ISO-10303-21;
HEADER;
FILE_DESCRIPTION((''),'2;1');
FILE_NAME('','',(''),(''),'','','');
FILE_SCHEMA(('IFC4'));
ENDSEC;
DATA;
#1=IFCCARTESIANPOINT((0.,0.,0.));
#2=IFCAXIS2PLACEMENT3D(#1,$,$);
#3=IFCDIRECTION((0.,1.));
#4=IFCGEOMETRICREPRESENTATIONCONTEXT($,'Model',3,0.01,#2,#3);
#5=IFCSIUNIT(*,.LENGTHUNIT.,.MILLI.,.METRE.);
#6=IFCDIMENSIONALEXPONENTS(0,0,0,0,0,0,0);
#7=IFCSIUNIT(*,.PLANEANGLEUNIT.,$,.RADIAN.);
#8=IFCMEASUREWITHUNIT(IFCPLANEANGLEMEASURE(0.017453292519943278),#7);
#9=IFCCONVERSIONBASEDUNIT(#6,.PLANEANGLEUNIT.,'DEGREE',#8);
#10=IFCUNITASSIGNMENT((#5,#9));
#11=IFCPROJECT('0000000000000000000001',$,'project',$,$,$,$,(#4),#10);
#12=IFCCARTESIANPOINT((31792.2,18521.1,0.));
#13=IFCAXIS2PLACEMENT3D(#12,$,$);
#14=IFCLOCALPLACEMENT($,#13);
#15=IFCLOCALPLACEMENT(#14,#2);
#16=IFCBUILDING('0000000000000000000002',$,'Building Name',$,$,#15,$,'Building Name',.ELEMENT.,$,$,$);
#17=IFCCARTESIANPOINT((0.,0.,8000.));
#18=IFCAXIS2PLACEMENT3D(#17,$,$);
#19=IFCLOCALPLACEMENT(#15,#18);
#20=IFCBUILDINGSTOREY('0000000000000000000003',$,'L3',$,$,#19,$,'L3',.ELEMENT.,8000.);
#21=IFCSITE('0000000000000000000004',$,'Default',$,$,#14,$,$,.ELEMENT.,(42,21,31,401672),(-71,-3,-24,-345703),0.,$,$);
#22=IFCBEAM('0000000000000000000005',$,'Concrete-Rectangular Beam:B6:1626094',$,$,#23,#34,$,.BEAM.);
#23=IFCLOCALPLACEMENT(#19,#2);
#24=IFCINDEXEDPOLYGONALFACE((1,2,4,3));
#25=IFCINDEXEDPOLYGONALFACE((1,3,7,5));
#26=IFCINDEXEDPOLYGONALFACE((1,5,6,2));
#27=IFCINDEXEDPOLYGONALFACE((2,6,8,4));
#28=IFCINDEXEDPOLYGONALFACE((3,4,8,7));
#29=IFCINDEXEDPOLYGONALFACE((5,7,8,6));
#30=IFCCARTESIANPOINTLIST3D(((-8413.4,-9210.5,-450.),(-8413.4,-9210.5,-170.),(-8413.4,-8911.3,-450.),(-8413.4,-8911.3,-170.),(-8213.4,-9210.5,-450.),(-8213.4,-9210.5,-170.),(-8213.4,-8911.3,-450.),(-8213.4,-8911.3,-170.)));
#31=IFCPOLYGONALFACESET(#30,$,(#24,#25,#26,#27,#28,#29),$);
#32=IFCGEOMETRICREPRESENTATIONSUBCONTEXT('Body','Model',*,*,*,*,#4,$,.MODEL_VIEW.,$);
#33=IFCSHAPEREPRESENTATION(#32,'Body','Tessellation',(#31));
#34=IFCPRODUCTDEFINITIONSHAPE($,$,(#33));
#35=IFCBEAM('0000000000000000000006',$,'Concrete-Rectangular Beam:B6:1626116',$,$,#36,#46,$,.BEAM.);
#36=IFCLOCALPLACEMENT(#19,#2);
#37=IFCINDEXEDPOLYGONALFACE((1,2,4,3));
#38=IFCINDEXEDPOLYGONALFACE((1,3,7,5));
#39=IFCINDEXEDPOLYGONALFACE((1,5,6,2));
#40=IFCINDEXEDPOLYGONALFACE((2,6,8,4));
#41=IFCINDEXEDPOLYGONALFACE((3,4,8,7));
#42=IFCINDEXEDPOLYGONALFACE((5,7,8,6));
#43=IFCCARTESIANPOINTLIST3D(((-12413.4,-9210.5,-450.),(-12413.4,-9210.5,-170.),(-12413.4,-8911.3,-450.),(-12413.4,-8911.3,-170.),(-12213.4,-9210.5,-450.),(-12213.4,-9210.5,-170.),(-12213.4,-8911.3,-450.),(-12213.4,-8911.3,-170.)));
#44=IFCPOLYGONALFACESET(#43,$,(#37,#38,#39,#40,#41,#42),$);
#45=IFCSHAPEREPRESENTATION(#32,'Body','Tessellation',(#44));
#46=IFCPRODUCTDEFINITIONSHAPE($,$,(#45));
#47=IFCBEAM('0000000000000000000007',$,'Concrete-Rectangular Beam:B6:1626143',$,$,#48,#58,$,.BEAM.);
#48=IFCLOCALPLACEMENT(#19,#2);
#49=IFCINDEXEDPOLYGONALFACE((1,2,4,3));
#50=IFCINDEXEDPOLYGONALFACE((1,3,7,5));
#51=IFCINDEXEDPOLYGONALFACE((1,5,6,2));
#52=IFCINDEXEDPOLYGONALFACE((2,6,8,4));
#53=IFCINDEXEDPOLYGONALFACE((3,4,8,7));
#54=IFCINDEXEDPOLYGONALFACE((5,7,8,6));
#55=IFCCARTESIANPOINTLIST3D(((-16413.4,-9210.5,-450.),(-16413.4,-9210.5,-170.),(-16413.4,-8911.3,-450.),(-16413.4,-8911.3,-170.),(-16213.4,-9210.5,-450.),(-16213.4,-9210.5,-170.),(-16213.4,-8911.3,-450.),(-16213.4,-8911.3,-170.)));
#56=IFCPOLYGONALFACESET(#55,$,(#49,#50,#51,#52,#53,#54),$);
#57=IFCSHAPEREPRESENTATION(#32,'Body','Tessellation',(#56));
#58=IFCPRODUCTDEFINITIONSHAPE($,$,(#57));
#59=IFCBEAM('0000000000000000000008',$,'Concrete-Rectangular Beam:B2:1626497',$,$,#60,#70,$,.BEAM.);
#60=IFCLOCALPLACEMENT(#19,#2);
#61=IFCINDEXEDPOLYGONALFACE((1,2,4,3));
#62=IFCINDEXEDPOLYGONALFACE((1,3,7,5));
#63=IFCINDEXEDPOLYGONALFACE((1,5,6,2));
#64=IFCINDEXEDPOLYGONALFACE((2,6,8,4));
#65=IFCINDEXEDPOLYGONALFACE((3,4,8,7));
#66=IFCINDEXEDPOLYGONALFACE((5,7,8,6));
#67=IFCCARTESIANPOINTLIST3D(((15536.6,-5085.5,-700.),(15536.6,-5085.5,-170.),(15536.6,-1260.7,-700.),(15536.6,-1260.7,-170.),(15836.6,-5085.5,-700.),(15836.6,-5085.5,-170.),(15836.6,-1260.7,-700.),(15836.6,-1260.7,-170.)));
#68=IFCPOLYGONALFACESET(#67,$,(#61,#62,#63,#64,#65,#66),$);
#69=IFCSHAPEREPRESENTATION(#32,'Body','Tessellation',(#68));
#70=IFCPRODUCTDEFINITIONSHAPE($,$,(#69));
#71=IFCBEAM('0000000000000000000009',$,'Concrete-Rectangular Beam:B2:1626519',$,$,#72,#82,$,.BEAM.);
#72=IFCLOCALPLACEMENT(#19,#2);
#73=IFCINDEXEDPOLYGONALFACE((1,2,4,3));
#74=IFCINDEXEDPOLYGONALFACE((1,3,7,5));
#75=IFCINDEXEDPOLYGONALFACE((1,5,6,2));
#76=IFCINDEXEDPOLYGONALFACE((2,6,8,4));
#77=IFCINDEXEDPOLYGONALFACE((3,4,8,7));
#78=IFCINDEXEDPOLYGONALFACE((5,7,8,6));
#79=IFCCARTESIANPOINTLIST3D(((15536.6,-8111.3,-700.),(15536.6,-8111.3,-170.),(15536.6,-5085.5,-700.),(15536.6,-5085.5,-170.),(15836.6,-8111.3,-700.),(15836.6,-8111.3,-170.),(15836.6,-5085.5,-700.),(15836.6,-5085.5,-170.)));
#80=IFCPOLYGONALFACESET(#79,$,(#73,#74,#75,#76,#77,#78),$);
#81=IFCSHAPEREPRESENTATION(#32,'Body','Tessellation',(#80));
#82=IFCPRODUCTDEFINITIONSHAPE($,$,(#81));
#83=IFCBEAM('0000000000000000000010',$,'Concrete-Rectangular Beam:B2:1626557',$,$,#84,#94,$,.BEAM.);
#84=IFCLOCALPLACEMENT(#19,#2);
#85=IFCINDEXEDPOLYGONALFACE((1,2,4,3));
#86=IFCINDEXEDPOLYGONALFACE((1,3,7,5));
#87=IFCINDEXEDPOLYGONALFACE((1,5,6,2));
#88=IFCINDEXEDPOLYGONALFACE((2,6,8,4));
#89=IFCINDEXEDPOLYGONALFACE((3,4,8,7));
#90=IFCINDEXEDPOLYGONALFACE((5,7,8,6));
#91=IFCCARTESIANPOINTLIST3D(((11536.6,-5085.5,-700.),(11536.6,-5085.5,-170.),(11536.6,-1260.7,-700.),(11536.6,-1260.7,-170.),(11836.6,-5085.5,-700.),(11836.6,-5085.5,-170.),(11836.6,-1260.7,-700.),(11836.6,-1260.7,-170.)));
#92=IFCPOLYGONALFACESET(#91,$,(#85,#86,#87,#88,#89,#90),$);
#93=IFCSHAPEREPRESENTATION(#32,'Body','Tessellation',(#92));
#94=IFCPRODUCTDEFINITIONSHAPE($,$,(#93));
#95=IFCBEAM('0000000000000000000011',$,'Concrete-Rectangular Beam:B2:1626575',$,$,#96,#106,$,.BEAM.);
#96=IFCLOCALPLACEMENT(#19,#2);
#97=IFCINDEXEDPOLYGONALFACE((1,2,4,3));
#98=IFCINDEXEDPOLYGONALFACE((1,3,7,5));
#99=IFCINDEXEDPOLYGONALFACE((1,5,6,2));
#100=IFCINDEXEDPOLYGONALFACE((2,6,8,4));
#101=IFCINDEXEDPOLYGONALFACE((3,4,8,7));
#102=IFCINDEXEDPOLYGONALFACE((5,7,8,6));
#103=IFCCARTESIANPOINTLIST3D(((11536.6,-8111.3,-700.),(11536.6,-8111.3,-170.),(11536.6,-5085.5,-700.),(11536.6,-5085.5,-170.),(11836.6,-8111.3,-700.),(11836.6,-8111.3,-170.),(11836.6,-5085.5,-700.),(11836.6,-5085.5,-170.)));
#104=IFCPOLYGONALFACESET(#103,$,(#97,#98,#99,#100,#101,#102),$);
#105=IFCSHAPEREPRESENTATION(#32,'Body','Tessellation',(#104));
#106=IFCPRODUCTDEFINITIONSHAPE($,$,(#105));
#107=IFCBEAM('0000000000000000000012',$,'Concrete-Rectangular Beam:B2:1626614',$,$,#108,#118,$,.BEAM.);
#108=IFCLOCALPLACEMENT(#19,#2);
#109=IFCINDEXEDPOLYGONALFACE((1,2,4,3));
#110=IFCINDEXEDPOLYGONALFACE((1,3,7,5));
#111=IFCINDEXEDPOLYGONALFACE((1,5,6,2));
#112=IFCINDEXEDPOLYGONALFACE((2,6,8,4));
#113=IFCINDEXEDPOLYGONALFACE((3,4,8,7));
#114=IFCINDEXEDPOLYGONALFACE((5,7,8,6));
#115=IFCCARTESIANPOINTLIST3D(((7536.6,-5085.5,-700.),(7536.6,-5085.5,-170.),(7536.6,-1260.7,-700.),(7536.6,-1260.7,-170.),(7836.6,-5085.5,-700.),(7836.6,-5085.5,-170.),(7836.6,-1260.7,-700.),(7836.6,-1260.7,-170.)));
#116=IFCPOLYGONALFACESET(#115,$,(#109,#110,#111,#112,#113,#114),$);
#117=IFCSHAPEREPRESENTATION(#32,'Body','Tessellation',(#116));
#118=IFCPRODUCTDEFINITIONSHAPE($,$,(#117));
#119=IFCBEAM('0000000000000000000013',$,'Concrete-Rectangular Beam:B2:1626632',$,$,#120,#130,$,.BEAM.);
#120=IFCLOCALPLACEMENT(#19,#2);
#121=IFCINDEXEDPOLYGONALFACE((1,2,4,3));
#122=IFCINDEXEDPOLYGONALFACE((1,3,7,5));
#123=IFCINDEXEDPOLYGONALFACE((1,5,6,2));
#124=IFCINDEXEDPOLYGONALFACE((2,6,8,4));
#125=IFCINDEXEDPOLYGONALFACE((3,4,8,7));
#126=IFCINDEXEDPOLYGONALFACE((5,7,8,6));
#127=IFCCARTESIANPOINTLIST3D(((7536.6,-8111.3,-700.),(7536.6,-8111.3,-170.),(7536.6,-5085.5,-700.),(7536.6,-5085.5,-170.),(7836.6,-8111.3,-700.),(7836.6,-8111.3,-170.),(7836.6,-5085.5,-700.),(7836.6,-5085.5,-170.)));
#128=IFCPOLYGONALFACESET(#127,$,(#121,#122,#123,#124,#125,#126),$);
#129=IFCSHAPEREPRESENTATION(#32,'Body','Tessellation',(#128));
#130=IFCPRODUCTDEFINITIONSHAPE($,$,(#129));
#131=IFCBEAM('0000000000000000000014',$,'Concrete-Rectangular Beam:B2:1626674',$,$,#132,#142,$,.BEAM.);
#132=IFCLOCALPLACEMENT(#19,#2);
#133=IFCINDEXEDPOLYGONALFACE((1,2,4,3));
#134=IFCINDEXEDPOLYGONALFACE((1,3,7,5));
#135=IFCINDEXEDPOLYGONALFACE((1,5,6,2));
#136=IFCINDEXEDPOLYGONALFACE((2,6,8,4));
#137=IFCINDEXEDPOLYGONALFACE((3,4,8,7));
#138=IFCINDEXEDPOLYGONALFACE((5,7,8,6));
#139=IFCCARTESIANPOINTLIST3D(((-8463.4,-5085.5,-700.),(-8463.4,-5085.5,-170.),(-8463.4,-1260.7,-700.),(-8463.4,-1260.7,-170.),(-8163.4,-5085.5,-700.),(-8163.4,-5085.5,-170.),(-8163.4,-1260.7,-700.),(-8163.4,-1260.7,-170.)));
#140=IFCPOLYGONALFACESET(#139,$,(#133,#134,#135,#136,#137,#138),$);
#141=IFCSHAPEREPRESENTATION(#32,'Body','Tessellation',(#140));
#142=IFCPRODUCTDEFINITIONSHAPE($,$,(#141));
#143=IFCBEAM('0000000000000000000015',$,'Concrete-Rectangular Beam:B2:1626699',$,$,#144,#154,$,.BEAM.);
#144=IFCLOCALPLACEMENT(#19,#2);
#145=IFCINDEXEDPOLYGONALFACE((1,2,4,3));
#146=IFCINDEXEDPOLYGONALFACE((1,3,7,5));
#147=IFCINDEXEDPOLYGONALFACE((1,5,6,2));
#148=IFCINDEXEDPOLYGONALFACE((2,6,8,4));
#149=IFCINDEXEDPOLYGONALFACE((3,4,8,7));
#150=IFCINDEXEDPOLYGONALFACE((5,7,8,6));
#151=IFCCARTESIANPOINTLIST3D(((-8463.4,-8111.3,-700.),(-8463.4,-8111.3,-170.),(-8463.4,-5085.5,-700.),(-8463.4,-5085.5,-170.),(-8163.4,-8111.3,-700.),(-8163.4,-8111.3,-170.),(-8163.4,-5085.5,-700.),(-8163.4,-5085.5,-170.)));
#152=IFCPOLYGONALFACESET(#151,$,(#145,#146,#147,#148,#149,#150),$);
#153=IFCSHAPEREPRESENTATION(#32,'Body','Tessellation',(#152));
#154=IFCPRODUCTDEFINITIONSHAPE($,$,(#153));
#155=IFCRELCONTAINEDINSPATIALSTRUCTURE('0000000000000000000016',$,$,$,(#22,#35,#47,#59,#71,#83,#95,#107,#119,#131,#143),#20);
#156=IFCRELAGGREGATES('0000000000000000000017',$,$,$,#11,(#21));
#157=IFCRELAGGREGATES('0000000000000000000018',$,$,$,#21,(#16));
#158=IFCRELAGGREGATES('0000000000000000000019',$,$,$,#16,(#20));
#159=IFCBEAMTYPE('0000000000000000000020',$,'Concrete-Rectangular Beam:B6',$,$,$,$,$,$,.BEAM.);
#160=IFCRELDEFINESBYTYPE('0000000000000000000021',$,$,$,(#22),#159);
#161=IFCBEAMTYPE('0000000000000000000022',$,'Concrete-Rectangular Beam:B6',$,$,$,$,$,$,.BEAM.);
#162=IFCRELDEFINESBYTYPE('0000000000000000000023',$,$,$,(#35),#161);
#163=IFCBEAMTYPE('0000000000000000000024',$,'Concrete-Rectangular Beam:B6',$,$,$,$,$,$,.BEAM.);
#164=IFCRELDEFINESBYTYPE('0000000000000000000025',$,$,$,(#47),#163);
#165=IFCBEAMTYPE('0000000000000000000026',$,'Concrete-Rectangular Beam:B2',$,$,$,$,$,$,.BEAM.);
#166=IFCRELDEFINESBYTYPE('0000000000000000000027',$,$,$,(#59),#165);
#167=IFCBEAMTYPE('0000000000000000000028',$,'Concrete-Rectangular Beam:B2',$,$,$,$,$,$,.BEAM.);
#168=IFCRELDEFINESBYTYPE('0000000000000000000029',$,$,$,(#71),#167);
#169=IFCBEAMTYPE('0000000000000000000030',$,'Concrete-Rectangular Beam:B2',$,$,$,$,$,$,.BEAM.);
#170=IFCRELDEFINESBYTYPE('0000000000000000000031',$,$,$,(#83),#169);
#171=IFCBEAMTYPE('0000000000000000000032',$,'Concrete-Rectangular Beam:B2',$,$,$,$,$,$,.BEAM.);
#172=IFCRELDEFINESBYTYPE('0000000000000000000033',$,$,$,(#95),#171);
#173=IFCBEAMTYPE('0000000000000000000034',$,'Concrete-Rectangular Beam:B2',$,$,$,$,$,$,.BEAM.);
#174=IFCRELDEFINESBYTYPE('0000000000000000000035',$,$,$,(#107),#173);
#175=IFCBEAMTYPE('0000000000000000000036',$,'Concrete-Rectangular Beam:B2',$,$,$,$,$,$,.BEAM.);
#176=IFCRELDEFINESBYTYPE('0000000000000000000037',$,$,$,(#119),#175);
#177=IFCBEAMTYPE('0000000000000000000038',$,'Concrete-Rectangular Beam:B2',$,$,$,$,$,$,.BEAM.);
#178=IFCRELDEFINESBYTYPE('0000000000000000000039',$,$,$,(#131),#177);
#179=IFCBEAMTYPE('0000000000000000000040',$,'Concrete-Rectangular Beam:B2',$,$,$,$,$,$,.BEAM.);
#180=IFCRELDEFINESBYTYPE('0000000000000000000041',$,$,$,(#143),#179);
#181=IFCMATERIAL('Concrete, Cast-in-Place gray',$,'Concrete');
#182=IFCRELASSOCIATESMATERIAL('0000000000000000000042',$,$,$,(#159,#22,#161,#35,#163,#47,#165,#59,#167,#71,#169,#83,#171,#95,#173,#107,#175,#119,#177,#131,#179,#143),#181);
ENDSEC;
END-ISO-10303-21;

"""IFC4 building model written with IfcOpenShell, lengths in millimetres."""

from ifc_helpers import new_model, entity, si_unit, converted_unit, direction, frame, origin, place, context, subcontext, project, spatial, indexed_curve, outline, extrude, source, transform, mapped, material, type_object, type_shapes, element, save


model = new_model("IFC4")

# Units and contexts
model_context = context("Model", 3, precision=0.01, world=origin(), true_north=direction((0.0, 1.0)))
body_context = subcontext(model_context, "Body", "Model", "MODEL_VIEW")
ifc_project = project(units=[si_unit("LENGTHUNIT", "METRE", prefix="MILLI"), converted_unit("PLANEANGLEUNIT", "DEGREE", entity("IfcPlaneAngleMeasure", 0.017453292519943278), si_unit("PLANEANGLEUNIT", "RADIAN"), dimensions=[0, 0, 0, 0, 0, 0, 0])], contexts=[model_context])

# Site, building, storey
site_placement = place(None, frame((31792.2, 18521.1, 0.0)))
site = spatial("IfcSite", under=ifc_project, at=site_placement, Name="Default", CompositionType="ELEMENT", RefLatitude=(42, 21, 31, 401672), RefLongitude=(-71, -3, -24, -345703), RefElevation=0.0)
building_placement = place(site_placement, origin())
building = spatial("IfcBuilding", under=site, at=building_placement, Name="Building Name", LongName="Building Name", CompositionType="ELEMENT")
storey_placement = place(building_placement, frame((0.0, 0.0, 8000.0)))
storey = spatial("IfcBuildingStorey", under=building, at=storey_placement, Name="L3", LongName="L3", CompositionType="ELEMENT", Elevation=8000.0)

# Beams
ifc_material = material(Name="Concrete, Cast-in-Place gray", Category="Concrete")
beam_type_1 = type_object("IfcBeamType", Name="Concrete-Rectangular Beam:B6", PredefinedType="BEAM", material=ifc_material)
shared_shape_1 = source(origin(), body_context, "Body", "SweptSolid", [
    extrude(outline(indexed_curve([(-100.0, -140.0), (100.0, -140.0), (100.0, 140.0), (-100.0, 140.0), (-100.0, -140.0)], self_intersect=False)), frame((-8313.4, -8911.3, 7690.0), z_axis=(0.0, -1.0, 0.0), x_axis=(-1.0, 0.0, 0.0)), (0.0, 0.0, 1.0), 299.2),
])
type_shapes(beam_type_1, [shared_shape_1])
beam_1_placement = place(storey_placement, frame((0.0, 0.0, -8000.0)))
element("IfcBeam", 1, at=beam_1_placement, inside=storey, type_object=beam_type_1, material=ifc_material, Name="Concrete-Rectangular Beam:B6:1626094", PredefinedType="BEAM", context=body_context, shape_type="MappedRepresentation", body=[
    mapped(shared_shape_1, transform((0.0, 0.0, 0.0), scale=1.0)),
])
beam_type_2 = type_object("IfcBeamType", Name="Concrete-Rectangular Beam:B6", PredefinedType="BEAM", material=ifc_material)
shared_shape_2 = source(origin(), body_context, "Body", "SweptSolid", [
    extrude(outline(indexed_curve([(-100.0, -140.0), (100.0, -140.0), (100.0, 140.0), (-100.0, 140.0), (-100.0, -140.0)], self_intersect=False)), frame((-12313.4, -8911.3, 7690.0), z_axis=(0.0, -1.0, 0.0), x_axis=(-1.0, 0.0, 0.0)), (0.0, 0.0, 1.0), 299.2),
])
type_shapes(beam_type_2, [shared_shape_2])
beam_2_placement = place(storey_placement, frame((0.0, 0.0, -8000.0)))
element("IfcBeam", 2, at=beam_2_placement, inside=storey, type_object=beam_type_2, material=ifc_material, Name="Concrete-Rectangular Beam:B6:1626116", PredefinedType="BEAM", context=body_context, shape_type="MappedRepresentation", body=[
    mapped(shared_shape_2, transform((0.0, 0.0, 0.0), scale=1.0)),
])
beam_type_3 = type_object("IfcBeamType", Name="Concrete-Rectangular Beam:B6", PredefinedType="BEAM", material=ifc_material)
shared_shape_3 = source(origin(), body_context, "Body", "SweptSolid", [
    extrude(outline(indexed_curve([(-100.0, -140.0), (100.0, -140.0), (100.0, 140.0), (-100.0, 140.0), (-100.0, -140.0)], self_intersect=False)), frame((-16313.4, -8911.3, 7690.0), z_axis=(0.0, -1.0, 0.0), x_axis=(-1.0, 0.0, 0.0)), (0.0, 0.0, 1.0), 299.2),
])
type_shapes(beam_type_3, [shared_shape_3])
beam_3_placement = place(storey_placement, frame((0.0, 0.0, -8000.0)))
element("IfcBeam", 3, at=beam_3_placement, inside=storey, type_object=beam_type_3, material=ifc_material, Name="Concrete-Rectangular Beam:B6:1626143", PredefinedType="BEAM", context=body_context, shape_type="MappedRepresentation", body=[
    mapped(shared_shape_3, transform((0.0, 0.0, 0.0), scale=1.0)),
])
beam_type_4 = type_object("IfcBeamType", Name="Concrete-Rectangular Beam:B2", PredefinedType="BEAM", material=ifc_material)
shared_shape_4 = source(origin(), body_context, "Body", "SweptSolid", [
    extrude(outline(indexed_curve([(-150.0, -265.0), (150.0, -265.0), (150.0, 265.0), (-150.0, 265.0), (-150.0, -265.0)], self_intersect=False)), frame((15686.6, -1260.7, 7565.0), z_axis=(0.0, -1.0, 0.0), x_axis=(-1.0, 0.0, 0.0)), (0.0, 0.0, 1.0), 3824.8),
])
type_shapes(beam_type_4, [shared_shape_4])
beam_4_placement = place(storey_placement, frame((0.0, 0.0, -8000.0)))
element("IfcBeam", 4, at=beam_4_placement, inside=storey, type_object=beam_type_4, material=ifc_material, Name="Concrete-Rectangular Beam:B2:1626497", PredefinedType="BEAM", context=body_context, shape_type="MappedRepresentation", body=[
    mapped(shared_shape_4, transform((0.0, 0.0, 0.0), scale=1.0)),
])
beam_type_5 = type_object("IfcBeamType", Name="Concrete-Rectangular Beam:B2", PredefinedType="BEAM", material=ifc_material)
shared_shape_5 = source(origin(), body_context, "Body", "SweptSolid", [
    extrude(outline(indexed_curve([(-150.0, -265.0), (150.0, -265.0), (150.0, 265.0), (-150.0, 265.0), (-150.0, -265.0)], self_intersect=False)), frame((15686.6, -5085.5, 7565.0), z_axis=(0.0, -1.0, 0.0), x_axis=(-1.0, 0.0, 0.0)), (0.0, 0.0, 1.0), 3025.8),
])
type_shapes(beam_type_5, [shared_shape_5])
beam_5_placement = place(storey_placement, frame((0.0, 0.0, -8000.0)))
element("IfcBeam", 5, at=beam_5_placement, inside=storey, type_object=beam_type_5, material=ifc_material, Name="Concrete-Rectangular Beam:B2:1626519", PredefinedType="BEAM", context=body_context, shape_type="MappedRepresentation", body=[
    mapped(shared_shape_5, transform((0.0, 0.0, 0.0), scale=1.0)),
])
beam_type_6 = type_object("IfcBeamType", Name="Concrete-Rectangular Beam:B2", PredefinedType="BEAM", material=ifc_material)
shared_shape_6 = source(origin(), body_context, "Body", "SweptSolid", [
    extrude(outline(indexed_curve([(-150.0, -265.0), (150.0, -265.0), (150.0, 265.0), (-150.0, 265.0), (-150.0, -265.0)], self_intersect=False)), frame((11686.6, -1260.7, 7565.0), z_axis=(0.0, -1.0, 0.0), x_axis=(-1.0, 0.0, 0.0)), (0.0, 0.0, 1.0), 3824.8),
])
type_shapes(beam_type_6, [shared_shape_6])
beam_6_placement = place(storey_placement, frame((0.0, 0.0, -8000.0)))
element("IfcBeam", 6, at=beam_6_placement, inside=storey, type_object=beam_type_6, material=ifc_material, Name="Concrete-Rectangular Beam:B2:1626557", PredefinedType="BEAM", context=body_context, shape_type="MappedRepresentation", body=[
    mapped(shared_shape_6, transform((0.0, 0.0, 0.0), scale=1.0)),
])
beam_type_7 = type_object("IfcBeamType", Name="Concrete-Rectangular Beam:B2", PredefinedType="BEAM", material=ifc_material)
shared_shape_7 = source(origin(), body_context, "Body", "SweptSolid", [
    extrude(outline(indexed_curve([(-150.0, -265.0), (150.0, -265.0), (150.0, 265.0), (-150.0, 265.0), (-150.0, -265.0)], self_intersect=False)), frame((11686.6, -5085.5, 7565.0), z_axis=(0.0, -1.0, 0.0), x_axis=(-1.0, 0.0, 0.0)), (0.0, 0.0, 1.0), 3025.8),
])
type_shapes(beam_type_7, [shared_shape_7])
beam_7_placement = place(storey_placement, frame((0.0, 0.0, -8000.0)))
element("IfcBeam", 7, at=beam_7_placement, inside=storey, type_object=beam_type_7, material=ifc_material, Name="Concrete-Rectangular Beam:B2:1626575", PredefinedType="BEAM", context=body_context, shape_type="MappedRepresentation", body=[
    mapped(shared_shape_7, transform((0.0, 0.0, 0.0), scale=1.0)),
])
beam_type_8 = type_object("IfcBeamType", Name="Concrete-Rectangular Beam:B2", PredefinedType="BEAM", material=ifc_material)
shared_shape_8 = source(origin(), body_context, "Body", "SweptSolid", [
    extrude(outline(indexed_curve([(-150.0, -265.0), (150.0, -265.0), (150.0, 265.0), (-150.0, 265.0), (-150.0, -265.0)], self_intersect=False)), frame((7686.6, -1260.7, 7565.0), z_axis=(0.0, -1.0, 0.0), x_axis=(-1.0, 0.0, 0.0)), (0.0, 0.0, 1.0), 3824.8),
])
type_shapes(beam_type_8, [shared_shape_8])
beam_8_placement = place(storey_placement, frame((0.0, 0.0, -8000.0)))
element("IfcBeam", 8, at=beam_8_placement, inside=storey, type_object=beam_type_8, material=ifc_material, Name="Concrete-Rectangular Beam:B2:1626614", PredefinedType="BEAM", context=body_context, shape_type="MappedRepresentation", body=[
    mapped(shared_shape_8, transform((0.0, 0.0, 0.0), scale=1.0)),
])
beam_type_9 = type_object("IfcBeamType", Name="Concrete-Rectangular Beam:B2", PredefinedType="BEAM", material=ifc_material)
shared_shape_9 = source(origin(), body_context, "Body", "SweptSolid", [
    extrude(outline(indexed_curve([(-150.0, -265.0), (150.0, -265.0), (150.0, 265.0), (-150.0, 265.0), (-150.0, -265.0)], self_intersect=False)), frame((7686.6, -5085.5, 7565.0), z_axis=(0.0, -1.0, 0.0), x_axis=(-1.0, 0.0, 0.0)), (0.0, 0.0, 1.0), 3025.8),
])
type_shapes(beam_type_9, [shared_shape_9])
beam_9_placement = place(storey_placement, frame((0.0, 0.0, -8000.0)))
element("IfcBeam", 9, at=beam_9_placement, inside=storey, type_object=beam_type_9, material=ifc_material, Name="Concrete-Rectangular Beam:B2:1626632", PredefinedType="BEAM", context=body_context, shape_type="MappedRepresentation", body=[
    mapped(shared_shape_9, transform((0.0, 0.0, 0.0), scale=1.0)),
])
beam_type_10 = type_object("IfcBeamType", Name="Concrete-Rectangular Beam:B2", PredefinedType="BEAM", material=ifc_material)
shared_shape_10 = source(origin(), body_context, "Body", "SweptSolid", [
    extrude(outline(indexed_curve([(-150.0, -265.0), (150.0, -265.0), (150.0, 265.0), (-150.0, 265.0), (-150.0, -265.0)], self_intersect=False)), frame((-8313.4, -1260.7, 7565.0), z_axis=(0.0, -1.0, 0.0), x_axis=(-1.0, 0.0, 0.0)), (0.0, 0.0, 1.0), 3824.8),
])
type_shapes(beam_type_10, [shared_shape_10])
beam_10_placement = place(storey_placement, frame((0.0, 0.0, -8000.0)))
element("IfcBeam", 10, at=beam_10_placement, inside=storey, type_object=beam_type_10, material=ifc_material, Name="Concrete-Rectangular Beam:B2:1626674", PredefinedType="BEAM", context=body_context, shape_type="MappedRepresentation", body=[
    mapped(shared_shape_10, transform((0.0, 0.0, 0.0), scale=1.0)),
])
beam_type_11 = type_object("IfcBeamType", Name="Concrete-Rectangular Beam:B2", PredefinedType="BEAM", material=ifc_material)
shared_shape_11 = source(origin(), body_context, "Body", "SweptSolid", [
    extrude(outline(indexed_curve([(-150.0, -265.0), (150.0, -265.0), (150.0, 265.0), (-150.0, 265.0), (-150.0, -265.0)], self_intersect=False)), frame((-8313.4, -5085.5, 7565.0), z_axis=(0.0, -1.0, 0.0), x_axis=(-1.0, 0.0, 0.0)), (0.0, 0.0, 1.0), 3025.8),
])
type_shapes(beam_type_11, [shared_shape_11])
beam_11_placement = place(storey_placement, frame((0.0, 0.0, -8000.0)))
element("IfcBeam", 11, at=beam_11_placement, inside=storey, type_object=beam_type_11, material=ifc_material, Name="Concrete-Rectangular Beam:B2:1626699", PredefinedType="BEAM", context=body_context, shape_type="MappedRepresentation", body=[
    mapped(shared_shape_11, transform((0.0, 0.0, 0.0), scale=1.0)),
])

save(model, "model.ifc")
